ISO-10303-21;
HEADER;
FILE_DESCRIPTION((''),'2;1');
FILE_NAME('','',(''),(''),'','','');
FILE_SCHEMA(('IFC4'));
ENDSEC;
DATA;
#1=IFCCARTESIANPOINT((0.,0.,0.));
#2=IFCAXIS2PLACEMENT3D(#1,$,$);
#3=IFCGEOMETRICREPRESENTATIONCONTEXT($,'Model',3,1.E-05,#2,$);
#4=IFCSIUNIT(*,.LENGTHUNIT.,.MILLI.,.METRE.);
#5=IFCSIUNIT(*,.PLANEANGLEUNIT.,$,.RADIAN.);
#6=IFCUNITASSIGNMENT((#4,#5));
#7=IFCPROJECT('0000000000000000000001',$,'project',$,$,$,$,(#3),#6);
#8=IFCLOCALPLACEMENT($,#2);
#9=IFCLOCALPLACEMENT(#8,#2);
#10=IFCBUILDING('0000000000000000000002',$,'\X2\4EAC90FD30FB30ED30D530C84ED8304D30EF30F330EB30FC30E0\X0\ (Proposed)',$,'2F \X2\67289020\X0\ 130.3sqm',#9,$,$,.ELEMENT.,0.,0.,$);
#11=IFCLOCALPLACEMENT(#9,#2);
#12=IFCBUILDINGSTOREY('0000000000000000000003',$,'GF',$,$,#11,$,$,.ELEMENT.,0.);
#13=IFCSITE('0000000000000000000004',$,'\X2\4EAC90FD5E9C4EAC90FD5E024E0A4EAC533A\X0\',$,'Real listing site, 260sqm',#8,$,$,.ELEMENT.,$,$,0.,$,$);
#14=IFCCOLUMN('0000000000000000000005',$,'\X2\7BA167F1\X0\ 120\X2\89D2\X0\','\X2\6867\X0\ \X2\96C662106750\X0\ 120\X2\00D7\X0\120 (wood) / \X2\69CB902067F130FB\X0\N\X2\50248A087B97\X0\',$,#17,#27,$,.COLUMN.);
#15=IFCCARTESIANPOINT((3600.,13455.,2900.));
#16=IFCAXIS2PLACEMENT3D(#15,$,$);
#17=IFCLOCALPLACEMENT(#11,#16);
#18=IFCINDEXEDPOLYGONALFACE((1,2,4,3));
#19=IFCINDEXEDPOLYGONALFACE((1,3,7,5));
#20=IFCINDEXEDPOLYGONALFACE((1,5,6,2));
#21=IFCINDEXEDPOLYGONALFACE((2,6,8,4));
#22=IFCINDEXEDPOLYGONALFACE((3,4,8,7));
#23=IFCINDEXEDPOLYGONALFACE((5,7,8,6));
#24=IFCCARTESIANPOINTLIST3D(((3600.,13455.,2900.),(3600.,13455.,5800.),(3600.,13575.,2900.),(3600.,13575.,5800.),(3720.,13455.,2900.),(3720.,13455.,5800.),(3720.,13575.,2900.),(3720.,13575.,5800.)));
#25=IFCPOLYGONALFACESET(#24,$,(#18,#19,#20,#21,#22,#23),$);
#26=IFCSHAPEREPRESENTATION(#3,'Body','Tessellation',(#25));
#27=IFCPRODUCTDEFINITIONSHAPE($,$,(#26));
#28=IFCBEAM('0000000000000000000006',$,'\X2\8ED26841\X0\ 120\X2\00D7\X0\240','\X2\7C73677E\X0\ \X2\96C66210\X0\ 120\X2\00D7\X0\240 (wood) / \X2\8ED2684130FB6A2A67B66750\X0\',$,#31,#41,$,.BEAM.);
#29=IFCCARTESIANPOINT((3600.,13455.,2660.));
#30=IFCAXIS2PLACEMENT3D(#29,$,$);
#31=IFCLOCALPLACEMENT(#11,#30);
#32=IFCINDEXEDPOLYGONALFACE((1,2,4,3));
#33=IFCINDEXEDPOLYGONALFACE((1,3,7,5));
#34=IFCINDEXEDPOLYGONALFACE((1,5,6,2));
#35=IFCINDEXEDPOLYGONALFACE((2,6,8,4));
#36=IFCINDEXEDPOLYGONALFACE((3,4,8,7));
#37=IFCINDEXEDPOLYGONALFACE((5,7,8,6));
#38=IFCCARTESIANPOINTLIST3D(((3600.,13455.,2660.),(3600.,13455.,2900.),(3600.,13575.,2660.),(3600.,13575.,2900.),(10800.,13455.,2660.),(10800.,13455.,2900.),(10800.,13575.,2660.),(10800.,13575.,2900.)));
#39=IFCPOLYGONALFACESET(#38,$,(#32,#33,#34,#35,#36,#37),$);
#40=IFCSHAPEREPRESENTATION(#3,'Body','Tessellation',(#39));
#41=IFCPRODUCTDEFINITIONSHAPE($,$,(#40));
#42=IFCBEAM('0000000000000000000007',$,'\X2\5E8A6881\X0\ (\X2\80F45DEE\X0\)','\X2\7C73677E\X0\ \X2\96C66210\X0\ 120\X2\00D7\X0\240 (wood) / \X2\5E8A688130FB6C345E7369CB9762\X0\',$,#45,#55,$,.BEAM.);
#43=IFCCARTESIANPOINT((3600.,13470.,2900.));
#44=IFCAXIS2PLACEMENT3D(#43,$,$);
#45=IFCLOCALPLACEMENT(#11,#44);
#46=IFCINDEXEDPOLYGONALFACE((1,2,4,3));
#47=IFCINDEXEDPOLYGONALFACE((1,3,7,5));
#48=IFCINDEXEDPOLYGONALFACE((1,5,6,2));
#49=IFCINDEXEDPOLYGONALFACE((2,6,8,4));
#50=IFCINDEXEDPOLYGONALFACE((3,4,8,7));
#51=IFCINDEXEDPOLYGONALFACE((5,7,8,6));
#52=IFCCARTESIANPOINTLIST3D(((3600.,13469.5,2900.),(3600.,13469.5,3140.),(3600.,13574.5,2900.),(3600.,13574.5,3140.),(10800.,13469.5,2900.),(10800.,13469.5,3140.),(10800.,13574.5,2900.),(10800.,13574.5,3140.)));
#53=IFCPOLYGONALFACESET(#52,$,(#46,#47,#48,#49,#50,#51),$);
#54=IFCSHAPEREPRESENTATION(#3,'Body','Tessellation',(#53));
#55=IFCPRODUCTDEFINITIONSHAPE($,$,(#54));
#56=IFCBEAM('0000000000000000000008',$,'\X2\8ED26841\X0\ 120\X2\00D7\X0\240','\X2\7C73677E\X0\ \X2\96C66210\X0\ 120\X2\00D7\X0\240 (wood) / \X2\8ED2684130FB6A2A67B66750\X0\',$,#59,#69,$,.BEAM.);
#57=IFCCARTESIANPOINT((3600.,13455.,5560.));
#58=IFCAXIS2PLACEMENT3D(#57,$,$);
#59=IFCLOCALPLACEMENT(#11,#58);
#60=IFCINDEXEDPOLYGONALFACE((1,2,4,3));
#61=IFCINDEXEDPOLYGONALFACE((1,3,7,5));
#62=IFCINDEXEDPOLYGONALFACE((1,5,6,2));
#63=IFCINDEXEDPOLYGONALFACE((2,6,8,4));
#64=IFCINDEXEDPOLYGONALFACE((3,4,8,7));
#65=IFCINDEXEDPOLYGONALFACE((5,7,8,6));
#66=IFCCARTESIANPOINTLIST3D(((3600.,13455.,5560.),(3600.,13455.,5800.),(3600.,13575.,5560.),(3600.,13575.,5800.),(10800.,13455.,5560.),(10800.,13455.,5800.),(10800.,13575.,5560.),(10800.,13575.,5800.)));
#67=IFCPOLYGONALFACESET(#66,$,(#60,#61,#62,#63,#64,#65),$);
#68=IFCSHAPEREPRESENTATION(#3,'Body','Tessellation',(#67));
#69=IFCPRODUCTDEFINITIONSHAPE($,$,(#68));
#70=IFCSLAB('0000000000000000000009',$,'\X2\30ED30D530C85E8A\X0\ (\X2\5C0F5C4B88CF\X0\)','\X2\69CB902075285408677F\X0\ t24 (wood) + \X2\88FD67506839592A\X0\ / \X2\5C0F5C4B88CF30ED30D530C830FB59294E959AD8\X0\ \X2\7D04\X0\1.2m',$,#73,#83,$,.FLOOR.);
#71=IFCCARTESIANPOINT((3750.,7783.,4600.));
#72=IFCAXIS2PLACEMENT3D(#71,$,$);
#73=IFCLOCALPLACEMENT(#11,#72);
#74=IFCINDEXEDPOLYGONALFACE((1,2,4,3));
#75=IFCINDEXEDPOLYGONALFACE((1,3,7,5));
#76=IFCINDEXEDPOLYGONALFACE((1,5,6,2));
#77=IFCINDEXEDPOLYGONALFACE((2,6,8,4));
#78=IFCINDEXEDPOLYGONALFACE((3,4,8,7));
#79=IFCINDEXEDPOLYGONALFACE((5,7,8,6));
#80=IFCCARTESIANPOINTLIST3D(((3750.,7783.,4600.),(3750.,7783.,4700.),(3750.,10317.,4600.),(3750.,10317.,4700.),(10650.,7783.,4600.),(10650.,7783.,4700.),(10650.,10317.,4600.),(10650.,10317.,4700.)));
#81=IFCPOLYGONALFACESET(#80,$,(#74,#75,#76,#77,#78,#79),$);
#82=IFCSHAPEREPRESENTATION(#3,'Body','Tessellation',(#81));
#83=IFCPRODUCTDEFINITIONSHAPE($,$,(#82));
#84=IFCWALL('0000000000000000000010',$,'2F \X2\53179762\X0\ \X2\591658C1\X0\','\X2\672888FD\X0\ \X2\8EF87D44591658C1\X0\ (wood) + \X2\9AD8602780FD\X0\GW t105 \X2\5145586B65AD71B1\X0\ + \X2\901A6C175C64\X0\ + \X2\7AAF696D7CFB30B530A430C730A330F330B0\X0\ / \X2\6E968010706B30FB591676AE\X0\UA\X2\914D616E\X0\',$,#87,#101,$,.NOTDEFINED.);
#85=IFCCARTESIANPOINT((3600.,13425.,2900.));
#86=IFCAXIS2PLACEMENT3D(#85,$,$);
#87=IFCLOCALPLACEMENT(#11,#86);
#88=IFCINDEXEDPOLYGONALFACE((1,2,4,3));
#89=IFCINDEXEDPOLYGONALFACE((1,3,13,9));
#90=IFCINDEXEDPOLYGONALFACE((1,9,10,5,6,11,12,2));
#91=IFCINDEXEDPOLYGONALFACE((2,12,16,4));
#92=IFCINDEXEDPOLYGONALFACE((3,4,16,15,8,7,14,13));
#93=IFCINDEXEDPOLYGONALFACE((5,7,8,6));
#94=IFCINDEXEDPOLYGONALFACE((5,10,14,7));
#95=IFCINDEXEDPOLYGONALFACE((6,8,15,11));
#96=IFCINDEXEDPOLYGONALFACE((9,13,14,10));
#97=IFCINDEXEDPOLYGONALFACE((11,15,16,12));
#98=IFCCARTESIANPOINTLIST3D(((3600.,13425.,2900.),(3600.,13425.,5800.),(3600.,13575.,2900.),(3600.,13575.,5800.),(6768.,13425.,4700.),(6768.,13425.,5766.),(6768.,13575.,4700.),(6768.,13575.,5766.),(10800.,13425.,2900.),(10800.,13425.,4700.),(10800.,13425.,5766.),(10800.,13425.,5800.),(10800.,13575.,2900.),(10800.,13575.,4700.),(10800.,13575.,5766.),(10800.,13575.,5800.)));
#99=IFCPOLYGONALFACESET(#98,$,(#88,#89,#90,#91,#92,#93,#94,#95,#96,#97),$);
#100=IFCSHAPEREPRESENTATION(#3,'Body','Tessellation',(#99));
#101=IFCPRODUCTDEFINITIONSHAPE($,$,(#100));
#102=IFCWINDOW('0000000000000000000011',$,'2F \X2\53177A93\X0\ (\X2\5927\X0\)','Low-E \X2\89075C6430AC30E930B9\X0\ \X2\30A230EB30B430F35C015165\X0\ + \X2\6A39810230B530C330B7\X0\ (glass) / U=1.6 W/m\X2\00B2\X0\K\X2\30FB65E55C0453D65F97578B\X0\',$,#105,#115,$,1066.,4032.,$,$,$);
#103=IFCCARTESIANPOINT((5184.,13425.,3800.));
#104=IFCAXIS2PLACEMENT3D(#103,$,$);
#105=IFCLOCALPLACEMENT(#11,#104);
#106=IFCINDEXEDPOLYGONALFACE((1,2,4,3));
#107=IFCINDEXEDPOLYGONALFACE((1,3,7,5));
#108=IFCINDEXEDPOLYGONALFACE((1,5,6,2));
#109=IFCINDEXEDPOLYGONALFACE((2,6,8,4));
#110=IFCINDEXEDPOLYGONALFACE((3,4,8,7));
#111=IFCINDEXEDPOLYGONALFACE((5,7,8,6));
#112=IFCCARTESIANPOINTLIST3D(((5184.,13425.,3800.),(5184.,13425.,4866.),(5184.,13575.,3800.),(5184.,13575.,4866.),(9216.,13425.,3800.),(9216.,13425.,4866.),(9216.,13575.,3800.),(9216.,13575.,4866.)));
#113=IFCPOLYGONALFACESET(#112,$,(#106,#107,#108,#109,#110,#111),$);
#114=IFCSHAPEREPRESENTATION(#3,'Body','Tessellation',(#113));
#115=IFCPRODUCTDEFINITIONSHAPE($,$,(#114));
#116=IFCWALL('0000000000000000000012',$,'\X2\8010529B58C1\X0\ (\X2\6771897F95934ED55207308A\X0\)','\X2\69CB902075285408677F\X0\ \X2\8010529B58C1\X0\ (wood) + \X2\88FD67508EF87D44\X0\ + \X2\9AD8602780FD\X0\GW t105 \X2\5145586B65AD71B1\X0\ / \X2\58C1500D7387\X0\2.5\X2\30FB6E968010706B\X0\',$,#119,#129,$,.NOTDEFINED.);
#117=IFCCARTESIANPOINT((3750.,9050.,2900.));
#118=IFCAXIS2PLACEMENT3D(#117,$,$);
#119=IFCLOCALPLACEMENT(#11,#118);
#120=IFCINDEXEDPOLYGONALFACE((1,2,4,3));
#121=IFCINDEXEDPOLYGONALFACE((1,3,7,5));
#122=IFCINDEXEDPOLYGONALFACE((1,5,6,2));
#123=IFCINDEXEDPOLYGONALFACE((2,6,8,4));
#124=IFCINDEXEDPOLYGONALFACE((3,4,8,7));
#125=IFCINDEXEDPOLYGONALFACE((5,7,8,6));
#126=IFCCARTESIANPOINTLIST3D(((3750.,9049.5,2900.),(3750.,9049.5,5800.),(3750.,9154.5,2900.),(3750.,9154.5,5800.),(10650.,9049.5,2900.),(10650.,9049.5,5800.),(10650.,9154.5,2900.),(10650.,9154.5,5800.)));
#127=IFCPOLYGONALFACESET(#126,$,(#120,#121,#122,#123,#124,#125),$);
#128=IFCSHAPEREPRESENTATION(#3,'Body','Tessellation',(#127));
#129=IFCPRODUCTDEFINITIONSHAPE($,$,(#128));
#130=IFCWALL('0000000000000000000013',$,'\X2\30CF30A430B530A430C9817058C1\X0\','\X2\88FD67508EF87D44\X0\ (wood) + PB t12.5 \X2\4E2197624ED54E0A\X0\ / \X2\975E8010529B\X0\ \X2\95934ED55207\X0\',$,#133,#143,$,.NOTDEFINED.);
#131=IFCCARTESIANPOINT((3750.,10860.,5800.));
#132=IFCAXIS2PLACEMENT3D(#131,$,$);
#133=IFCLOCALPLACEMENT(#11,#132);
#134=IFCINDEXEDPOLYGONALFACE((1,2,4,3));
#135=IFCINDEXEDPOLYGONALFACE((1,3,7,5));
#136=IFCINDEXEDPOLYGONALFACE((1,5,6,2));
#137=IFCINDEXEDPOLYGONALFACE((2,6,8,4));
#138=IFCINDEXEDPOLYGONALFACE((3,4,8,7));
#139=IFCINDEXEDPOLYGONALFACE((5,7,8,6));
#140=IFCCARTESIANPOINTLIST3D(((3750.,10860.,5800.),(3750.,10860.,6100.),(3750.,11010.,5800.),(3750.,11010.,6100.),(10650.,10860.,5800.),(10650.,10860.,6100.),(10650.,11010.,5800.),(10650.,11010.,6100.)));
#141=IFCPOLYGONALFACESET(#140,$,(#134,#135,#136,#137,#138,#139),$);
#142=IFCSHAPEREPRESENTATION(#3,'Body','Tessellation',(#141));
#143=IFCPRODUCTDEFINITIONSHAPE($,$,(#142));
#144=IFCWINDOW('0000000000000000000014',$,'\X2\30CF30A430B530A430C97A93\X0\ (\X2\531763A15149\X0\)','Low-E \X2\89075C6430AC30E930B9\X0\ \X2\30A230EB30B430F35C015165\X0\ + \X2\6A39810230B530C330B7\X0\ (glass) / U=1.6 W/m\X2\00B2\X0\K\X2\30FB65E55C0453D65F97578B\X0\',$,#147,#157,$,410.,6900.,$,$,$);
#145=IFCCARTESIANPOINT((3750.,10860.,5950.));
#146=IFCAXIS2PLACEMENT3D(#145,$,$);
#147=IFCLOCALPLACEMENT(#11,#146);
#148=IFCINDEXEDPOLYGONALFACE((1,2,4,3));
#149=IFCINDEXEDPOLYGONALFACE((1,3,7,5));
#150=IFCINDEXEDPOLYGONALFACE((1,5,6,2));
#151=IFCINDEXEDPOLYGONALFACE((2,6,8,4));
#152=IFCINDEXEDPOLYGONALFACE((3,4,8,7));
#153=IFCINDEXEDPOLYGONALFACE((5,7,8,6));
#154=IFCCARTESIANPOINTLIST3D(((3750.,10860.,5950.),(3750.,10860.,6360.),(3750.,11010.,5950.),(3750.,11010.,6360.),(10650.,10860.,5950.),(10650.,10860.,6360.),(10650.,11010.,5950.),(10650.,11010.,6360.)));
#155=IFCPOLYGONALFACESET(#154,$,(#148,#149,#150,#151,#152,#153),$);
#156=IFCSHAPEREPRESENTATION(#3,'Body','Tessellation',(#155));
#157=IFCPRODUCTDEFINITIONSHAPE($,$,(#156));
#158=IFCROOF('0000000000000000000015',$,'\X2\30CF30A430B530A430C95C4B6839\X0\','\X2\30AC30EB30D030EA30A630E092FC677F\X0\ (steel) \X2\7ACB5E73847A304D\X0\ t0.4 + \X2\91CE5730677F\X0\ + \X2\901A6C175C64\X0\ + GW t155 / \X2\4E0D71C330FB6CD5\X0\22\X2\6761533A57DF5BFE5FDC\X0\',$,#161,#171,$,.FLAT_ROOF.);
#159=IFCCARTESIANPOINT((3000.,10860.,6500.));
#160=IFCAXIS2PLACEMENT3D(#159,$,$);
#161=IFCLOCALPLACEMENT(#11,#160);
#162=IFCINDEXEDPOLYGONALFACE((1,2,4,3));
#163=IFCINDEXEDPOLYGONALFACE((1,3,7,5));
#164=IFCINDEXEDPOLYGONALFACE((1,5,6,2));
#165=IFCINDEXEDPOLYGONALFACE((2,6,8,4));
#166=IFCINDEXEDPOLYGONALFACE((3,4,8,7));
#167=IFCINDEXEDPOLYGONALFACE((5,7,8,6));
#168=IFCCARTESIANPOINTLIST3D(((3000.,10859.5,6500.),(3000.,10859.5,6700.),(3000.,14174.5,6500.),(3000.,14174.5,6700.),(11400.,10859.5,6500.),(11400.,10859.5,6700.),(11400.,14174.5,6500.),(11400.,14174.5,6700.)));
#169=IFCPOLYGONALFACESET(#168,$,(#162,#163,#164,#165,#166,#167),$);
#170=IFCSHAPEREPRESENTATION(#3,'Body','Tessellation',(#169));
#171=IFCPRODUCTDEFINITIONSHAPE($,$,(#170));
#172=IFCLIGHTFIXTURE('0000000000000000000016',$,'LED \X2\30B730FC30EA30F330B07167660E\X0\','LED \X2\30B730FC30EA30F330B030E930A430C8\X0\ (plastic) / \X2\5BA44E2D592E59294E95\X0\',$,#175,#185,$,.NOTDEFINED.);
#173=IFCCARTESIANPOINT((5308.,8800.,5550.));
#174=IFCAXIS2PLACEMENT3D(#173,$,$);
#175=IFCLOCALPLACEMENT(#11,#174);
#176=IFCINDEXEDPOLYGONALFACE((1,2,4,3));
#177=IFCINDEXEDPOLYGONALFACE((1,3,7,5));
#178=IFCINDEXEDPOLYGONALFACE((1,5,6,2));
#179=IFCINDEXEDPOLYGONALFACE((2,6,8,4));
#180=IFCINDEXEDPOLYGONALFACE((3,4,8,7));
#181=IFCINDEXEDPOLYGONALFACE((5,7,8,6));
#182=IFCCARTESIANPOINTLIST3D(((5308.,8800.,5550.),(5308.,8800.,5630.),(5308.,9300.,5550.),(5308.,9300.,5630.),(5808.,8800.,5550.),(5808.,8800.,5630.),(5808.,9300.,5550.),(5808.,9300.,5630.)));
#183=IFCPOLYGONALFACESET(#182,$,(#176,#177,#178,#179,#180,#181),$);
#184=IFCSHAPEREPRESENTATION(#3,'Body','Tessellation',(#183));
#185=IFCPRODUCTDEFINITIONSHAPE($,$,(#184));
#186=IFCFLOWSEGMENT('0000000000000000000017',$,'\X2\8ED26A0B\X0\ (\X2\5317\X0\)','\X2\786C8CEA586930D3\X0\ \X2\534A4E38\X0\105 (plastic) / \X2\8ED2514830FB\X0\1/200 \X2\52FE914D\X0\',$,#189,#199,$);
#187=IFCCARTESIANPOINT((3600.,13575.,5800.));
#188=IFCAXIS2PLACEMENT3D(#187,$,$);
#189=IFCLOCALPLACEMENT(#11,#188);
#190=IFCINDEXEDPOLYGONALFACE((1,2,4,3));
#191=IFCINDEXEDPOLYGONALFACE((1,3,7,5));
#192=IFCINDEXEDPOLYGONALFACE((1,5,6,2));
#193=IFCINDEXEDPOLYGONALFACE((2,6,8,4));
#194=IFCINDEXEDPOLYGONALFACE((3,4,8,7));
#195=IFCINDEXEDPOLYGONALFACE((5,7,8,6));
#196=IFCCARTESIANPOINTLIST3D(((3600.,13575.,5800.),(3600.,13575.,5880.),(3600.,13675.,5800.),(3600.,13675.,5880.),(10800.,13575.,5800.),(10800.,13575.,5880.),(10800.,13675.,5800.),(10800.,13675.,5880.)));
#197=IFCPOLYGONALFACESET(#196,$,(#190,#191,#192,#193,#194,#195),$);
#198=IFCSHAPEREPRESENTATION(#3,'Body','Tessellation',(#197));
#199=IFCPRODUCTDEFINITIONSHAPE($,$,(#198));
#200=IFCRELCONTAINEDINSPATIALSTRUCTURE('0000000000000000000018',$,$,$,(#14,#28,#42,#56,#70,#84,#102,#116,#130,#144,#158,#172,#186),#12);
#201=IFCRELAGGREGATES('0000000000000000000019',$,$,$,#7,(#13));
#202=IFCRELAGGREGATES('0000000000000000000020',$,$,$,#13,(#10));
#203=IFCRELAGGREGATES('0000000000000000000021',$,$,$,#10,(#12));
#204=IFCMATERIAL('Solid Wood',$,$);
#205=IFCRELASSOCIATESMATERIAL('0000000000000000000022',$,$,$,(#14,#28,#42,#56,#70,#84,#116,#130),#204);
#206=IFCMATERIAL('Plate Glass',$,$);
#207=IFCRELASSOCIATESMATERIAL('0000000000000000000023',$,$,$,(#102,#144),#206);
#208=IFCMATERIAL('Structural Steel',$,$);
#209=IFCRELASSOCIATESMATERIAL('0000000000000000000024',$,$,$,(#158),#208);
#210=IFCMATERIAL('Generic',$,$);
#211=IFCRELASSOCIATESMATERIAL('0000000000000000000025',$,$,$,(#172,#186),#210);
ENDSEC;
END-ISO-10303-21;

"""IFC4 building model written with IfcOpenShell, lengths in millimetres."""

from ifc_helpers import new_model, si_unit, frame, frame_2d, origin, place, context, project, spatial, rectangle, extrude, material, element, fill, save


model = new_model("IFC4")

# Units and contexts
model_context = context("Model", 3, precision=1e-05, world=origin())
ifc_project = project(units=[si_unit("LENGTHUNIT", "METRE", prefix="MILLI"), si_unit("PLANEANGLEUNIT", "RADIAN")], contexts=[model_context])

# Site, building, storey
site_placement = place(None, origin())
site = spatial("IfcSite", under=ifc_project, at=site_placement, Name="京都府京都市上京区", ObjectType="Real listing site, 260sqm", CompositionType="ELEMENT", RefElevation=0.0)
building_placement = place(site_placement, origin())
building = spatial("IfcBuilding", under=site, at=building_placement, Name="京都・ロフト付きワンルーム (Proposed)", ObjectType="2F 木造 130.3sqm", CompositionType="ELEMENT", ElevationOfRefHeight=0.0, ElevationOfTerrain=0.0)
storey_placement = place(building_placement, origin())
storey = spatial("IfcBuildingStorey", under=building, at=storey_placement, Name="GF", CompositionType="ELEMENT", Elevation=0.0)

# Column
ifc_material_1 = material(Name="Solid Wood")
column_1_placement = place(storey_placement, frame((3600.0, 13455.0, 2900.0)))
element("IfcColumn", 1, at=column_1_placement, inside=storey, material=ifc_material_1, Name="管柱 120角", Description="桧 集成材 120×120 (wood) / 構造柱・N値計算", PredefinedType="COLUMN", context=model_context, shape_type="SweptSolid", body=[
    extrude(rectangle(XDim=120.0, YDim=120.0, at=frame_2d((60.0, 60.0))), frame((3600.0, 13455.0, 2900.0)), (0.0, 0.0, 1.0), 2900.0),
])

# Beams
beam_1_placement = place(storey_placement, frame((3600.0, 13455.0, 2660.0)))
element("IfcBeam", 2, at=beam_1_placement, inside=storey, material=ifc_material_1, Name="軒桁 120×240", Description="米松 集成 120×240 (wood) / 軒桁・横架材", PredefinedType="BEAM", context=model_context, shape_type="SweptSolid", body=[
    extrude(rectangle(XDim=7200.0, YDim=120.0, at=frame_2d((3600.0, 60.0))), frame((3600.0, 13455.0, 2660.0)), (0.0, 0.0, 1.0), 240.0),
])
beam_2_placement = place(storey_placement, frame((3600.0, 13470.0, 2900.0)))
element("IfcBeam", 3, at=beam_2_placement, inside=storey, material=ifc_material_1, Name="床梁 (胴差)", Description="米松 集成 120×240 (wood) / 床梁・水平構面", PredefinedType="BEAM", context=model_context, shape_type="SweptSolid", body=[
    extrude(rectangle(XDim=7200.0, YDim=105.0, at=frame_2d((3600.0, 52.0))), frame((3600.0, 13470.0, 2900.0)), (0.0, 0.0, 1.0), 240.0),
])
beam_3_placement = place(storey_placement, frame((3600.0, 13455.0, 5560.0)))
element("IfcBeam", 4, at=beam_3_placement, inside=storey, material=ifc_material_1, Name="軒桁 120×240", Description="米松 集成 120×240 (wood) / 軒桁・横架材", PredefinedType="BEAM", context=model_context, shape_type="SweptSolid", body=[
    extrude(rectangle(XDim=7200.0, YDim=120.0, at=frame_2d((3600.0, 60.0))), frame((3600.0, 13455.0, 5560.0)), (0.0, 0.0, 1.0), 240.0),
])

# Slab
slab_placement = place(storey_placement, frame((3750.0, 7783.0, 4600.0)))
element("IfcSlab", 5, at=slab_placement, inside=storey, material=ifc_material_1, Name="ロフト床 (小屋裏)", Description="構造用合板 t24 (wood) + 製材根太 / 小屋裏ロフト・天井高 約1.2m", PredefinedType="FLOOR", context=model_context, shape_type="SweptSolid", body=[
    extrude(rectangle(XDim=6900.0, YDim=2534.0, at=frame_2d((3450.0, 1267.0))), frame((3750.0, 7783.0, 4600.0)), (0.0, 0.0, 1.0), 100.0),
])

# Wall, opening, window
wall_1_placement = place(storey_placement, frame((3600.0, 13425.0, 2900.0)))
wall_1 = element("IfcWall", 6, at=wall_1_placement, inside=storey, material=ifc_material_1, Name="2F 北面 外壁", Description="木製 軸組外壁 (wood) + 高性能GW t105 充填断熱 + 通気層 + 窯業系サイディング / 準耐火・外皮UA配慮", PredefinedType="NOTDEFINED", context=model_context, shape_type="SweptSolid", body=[
    extrude(rectangle(XDim=7200.0, YDim=150.0, at=frame_2d((3600.0, 75.0))), frame((3600.0, 13425.0, 2900.0)), (0.0, 0.0, 1.0), 2900.0),
])
opening_1_placement = place(storey_placement, frame((5184.0, 13425.0, 3800.0)))
opening_1 = element("IfcOpeningElement", 7, at=opening_1_placement, cuts=wall_1, PredefinedType="NOTDEFINED", context=model_context, shape_type="SweptSolid", body=[
    extrude(rectangle(XDim=4032.0, YDim=150.0, at=frame_2d((2016.0, 75.0))), frame((5184.0, 13425.0, 3800.0)), (0.0, 0.0, 1.0), 1066.0),
])
ifc_material_2 = material(Name="Plate Glass")
window_1_placement = place(storey_placement, frame((5184.0, 13425.0, 3800.0)))
window_1 = element("IfcWindow", 8, at=window_1_placement, inside=storey, material=ifc_material_2, Name="2F 北窓 (大)", Description="Low-E 複層ガラス アルゴン封入 + 樹脂サッシ (glass) / U=1.6 W/m²K・日射取得型", OverallHeight=1066.0, OverallWidth=4032.0, context=model_context, shape_type="SweptSolid", body=[
    extrude(rectangle(XDim=4032.0, YDim=150.0, at=frame_2d((2016.0, 75.0))), frame((5184.0, 13425.0, 3800.0)), (0.0, 0.0, 1.0), 1066.0),
])
fill(opening_1, window_1)

# Wall
wall_2_placement = place(storey_placement, frame((3750.0, 9050.0, 2900.0)))
element("IfcWall", 9, at=wall_2_placement, inside=storey, material=ifc_material_1, Name="耐力壁 (東西間仕切り)", Description="構造用合板 耐力壁 (wood) + 製材軸組 + 高性能GW t105 充填断熱 / 壁倍率2.5・準耐火", PredefinedType="NOTDEFINED", context=model_context, shape_type="SweptSolid", body=[
    extrude(rectangle(XDim=6900.0, YDim=105.0, at=frame_2d((3450.0, 52.0))), frame((3750.0, 9050.0, 2900.0)), (0.0, 0.0, 1.0), 2900.0),
])

# Wall, opening, window
wall_3_placement = place(storey_placement, frame((3750.0, 10860.0, 5800.0)))
wall_3 = element("IfcWall", 10, at=wall_3_placement, inside=storey, material=ifc_material_1, Name="ハイサイド腰壁", Description="製材軸組 (wood) + PB t12.5 両面仕上 / 非耐力 間仕切", PredefinedType="NOTDEFINED", context=model_context, shape_type="SweptSolid", body=[
    extrude(rectangle(XDim=6900.0, YDim=150.0, at=frame_2d((3450.0, 75.0))), frame((3750.0, 10860.0, 5800.0)), (0.0, 0.0, 1.0), 700.0),
])
opening_2_placement = place(storey_placement, frame((3750.0, 10860.0, 5950.0)))
opening_2 = element("IfcOpeningElement", 11, at=opening_2_placement, cuts=wall_3, PredefinedType="NOTDEFINED", context=model_context, shape_type="SweptSolid", body=[
    extrude(rectangle(XDim=6900.0, YDim=150.0, at=frame_2d((3450.0, 75.0))), frame((3750.0, 10860.0, 5950.0)), (0.0, 0.0, 1.0), 410.0),
])
window_2_placement = place(storey_placement, frame((3750.0, 10860.0, 5950.0)))
window_2 = element("IfcWindow", 12, at=window_2_placement, inside=storey, material=ifc_material_2, Name="ハイサイド窓 (北採光)", Description="Low-E 複層ガラス アルゴン封入 + 樹脂サッシ (glass) / U=1.6 W/m²K・日射取得型", OverallHeight=410.0, OverallWidth=6900.0, context=model_context, shape_type="SweptSolid", body=[
    extrude(rectangle(XDim=6900.0, YDim=150.0, at=frame_2d((3450.0, 75.0))), frame((3750.0, 10860.0, 5950.0)), (0.0, 0.0, 1.0), 410.0),
])
fill(opening_2, window_2)

# Roof
ifc_material_3 = material(Name="Structural Steel")
roof_placement = place(storey_placement, frame((3000.0, 10860.0, 6500.0)))
element("IfcRoof", 13, at=roof_placement, inside=storey, material=ifc_material_3, Name="ハイサイド屋根", Description="ガルバリウム鋼板 (steel) 立平葺き t0.4 + 野地板 + 通気層 + GW t155 / 不燃・法22条区域対応", PredefinedType="FLAT_ROOF", context=model_context, shape_type="SweptSolid", body=[
    extrude(rectangle(XDim=8400.0, YDim=3315.0, at=frame_2d((4200.0, 1657.0))), frame((3000.0, 10860.0, 6500.0)), (0.0, 0.0, 1.0), 200.0),
])

# Light fixture
ifc_material_4 = material(Name="Generic")
light_fixture_placement = place(storey_placement, frame((5308.0, 8800.0, 5550.0)))
element("IfcLightFixture", 14, at=light_fixture_placement, inside=storey, material=ifc_material_4, Name="LED シーリング照明", Description="LED シーリングライト (plastic) / 室中央天井", PredefinedType="NOTDEFINED", context=model_context, shape_type="SweptSolid", body=[
    extrude(rectangle(XDim=500.0, YDim=500.0, at=frame_2d((250.0, 250.0))), frame((5308.0, 8800.0, 5550.0)), (0.0, 0.0, 1.0), 80.0),
])

# Flow segment
flow_segment_placement = place(storey_placement, frame((3600.0, 13575.0, 5800.0)))
element("IfcFlowSegment", 15, at=flow_segment_placement, inside=storey, material=ifc_material_4, Name="軒樋 (北)", Description="硬質塩ビ 半丸105 (plastic) / 軒先・1/200 勾配", context=model_context, shape_type="SweptSolid", body=[
    extrude(rectangle(XDim=7200.0, YDim=100.0, at=frame_2d((3600.0, 50.0))), frame((3600.0, 13575.0, 5800.0)), (0.0, 0.0, 1.0), 80.0),
])

save(model, "model.ifc")
